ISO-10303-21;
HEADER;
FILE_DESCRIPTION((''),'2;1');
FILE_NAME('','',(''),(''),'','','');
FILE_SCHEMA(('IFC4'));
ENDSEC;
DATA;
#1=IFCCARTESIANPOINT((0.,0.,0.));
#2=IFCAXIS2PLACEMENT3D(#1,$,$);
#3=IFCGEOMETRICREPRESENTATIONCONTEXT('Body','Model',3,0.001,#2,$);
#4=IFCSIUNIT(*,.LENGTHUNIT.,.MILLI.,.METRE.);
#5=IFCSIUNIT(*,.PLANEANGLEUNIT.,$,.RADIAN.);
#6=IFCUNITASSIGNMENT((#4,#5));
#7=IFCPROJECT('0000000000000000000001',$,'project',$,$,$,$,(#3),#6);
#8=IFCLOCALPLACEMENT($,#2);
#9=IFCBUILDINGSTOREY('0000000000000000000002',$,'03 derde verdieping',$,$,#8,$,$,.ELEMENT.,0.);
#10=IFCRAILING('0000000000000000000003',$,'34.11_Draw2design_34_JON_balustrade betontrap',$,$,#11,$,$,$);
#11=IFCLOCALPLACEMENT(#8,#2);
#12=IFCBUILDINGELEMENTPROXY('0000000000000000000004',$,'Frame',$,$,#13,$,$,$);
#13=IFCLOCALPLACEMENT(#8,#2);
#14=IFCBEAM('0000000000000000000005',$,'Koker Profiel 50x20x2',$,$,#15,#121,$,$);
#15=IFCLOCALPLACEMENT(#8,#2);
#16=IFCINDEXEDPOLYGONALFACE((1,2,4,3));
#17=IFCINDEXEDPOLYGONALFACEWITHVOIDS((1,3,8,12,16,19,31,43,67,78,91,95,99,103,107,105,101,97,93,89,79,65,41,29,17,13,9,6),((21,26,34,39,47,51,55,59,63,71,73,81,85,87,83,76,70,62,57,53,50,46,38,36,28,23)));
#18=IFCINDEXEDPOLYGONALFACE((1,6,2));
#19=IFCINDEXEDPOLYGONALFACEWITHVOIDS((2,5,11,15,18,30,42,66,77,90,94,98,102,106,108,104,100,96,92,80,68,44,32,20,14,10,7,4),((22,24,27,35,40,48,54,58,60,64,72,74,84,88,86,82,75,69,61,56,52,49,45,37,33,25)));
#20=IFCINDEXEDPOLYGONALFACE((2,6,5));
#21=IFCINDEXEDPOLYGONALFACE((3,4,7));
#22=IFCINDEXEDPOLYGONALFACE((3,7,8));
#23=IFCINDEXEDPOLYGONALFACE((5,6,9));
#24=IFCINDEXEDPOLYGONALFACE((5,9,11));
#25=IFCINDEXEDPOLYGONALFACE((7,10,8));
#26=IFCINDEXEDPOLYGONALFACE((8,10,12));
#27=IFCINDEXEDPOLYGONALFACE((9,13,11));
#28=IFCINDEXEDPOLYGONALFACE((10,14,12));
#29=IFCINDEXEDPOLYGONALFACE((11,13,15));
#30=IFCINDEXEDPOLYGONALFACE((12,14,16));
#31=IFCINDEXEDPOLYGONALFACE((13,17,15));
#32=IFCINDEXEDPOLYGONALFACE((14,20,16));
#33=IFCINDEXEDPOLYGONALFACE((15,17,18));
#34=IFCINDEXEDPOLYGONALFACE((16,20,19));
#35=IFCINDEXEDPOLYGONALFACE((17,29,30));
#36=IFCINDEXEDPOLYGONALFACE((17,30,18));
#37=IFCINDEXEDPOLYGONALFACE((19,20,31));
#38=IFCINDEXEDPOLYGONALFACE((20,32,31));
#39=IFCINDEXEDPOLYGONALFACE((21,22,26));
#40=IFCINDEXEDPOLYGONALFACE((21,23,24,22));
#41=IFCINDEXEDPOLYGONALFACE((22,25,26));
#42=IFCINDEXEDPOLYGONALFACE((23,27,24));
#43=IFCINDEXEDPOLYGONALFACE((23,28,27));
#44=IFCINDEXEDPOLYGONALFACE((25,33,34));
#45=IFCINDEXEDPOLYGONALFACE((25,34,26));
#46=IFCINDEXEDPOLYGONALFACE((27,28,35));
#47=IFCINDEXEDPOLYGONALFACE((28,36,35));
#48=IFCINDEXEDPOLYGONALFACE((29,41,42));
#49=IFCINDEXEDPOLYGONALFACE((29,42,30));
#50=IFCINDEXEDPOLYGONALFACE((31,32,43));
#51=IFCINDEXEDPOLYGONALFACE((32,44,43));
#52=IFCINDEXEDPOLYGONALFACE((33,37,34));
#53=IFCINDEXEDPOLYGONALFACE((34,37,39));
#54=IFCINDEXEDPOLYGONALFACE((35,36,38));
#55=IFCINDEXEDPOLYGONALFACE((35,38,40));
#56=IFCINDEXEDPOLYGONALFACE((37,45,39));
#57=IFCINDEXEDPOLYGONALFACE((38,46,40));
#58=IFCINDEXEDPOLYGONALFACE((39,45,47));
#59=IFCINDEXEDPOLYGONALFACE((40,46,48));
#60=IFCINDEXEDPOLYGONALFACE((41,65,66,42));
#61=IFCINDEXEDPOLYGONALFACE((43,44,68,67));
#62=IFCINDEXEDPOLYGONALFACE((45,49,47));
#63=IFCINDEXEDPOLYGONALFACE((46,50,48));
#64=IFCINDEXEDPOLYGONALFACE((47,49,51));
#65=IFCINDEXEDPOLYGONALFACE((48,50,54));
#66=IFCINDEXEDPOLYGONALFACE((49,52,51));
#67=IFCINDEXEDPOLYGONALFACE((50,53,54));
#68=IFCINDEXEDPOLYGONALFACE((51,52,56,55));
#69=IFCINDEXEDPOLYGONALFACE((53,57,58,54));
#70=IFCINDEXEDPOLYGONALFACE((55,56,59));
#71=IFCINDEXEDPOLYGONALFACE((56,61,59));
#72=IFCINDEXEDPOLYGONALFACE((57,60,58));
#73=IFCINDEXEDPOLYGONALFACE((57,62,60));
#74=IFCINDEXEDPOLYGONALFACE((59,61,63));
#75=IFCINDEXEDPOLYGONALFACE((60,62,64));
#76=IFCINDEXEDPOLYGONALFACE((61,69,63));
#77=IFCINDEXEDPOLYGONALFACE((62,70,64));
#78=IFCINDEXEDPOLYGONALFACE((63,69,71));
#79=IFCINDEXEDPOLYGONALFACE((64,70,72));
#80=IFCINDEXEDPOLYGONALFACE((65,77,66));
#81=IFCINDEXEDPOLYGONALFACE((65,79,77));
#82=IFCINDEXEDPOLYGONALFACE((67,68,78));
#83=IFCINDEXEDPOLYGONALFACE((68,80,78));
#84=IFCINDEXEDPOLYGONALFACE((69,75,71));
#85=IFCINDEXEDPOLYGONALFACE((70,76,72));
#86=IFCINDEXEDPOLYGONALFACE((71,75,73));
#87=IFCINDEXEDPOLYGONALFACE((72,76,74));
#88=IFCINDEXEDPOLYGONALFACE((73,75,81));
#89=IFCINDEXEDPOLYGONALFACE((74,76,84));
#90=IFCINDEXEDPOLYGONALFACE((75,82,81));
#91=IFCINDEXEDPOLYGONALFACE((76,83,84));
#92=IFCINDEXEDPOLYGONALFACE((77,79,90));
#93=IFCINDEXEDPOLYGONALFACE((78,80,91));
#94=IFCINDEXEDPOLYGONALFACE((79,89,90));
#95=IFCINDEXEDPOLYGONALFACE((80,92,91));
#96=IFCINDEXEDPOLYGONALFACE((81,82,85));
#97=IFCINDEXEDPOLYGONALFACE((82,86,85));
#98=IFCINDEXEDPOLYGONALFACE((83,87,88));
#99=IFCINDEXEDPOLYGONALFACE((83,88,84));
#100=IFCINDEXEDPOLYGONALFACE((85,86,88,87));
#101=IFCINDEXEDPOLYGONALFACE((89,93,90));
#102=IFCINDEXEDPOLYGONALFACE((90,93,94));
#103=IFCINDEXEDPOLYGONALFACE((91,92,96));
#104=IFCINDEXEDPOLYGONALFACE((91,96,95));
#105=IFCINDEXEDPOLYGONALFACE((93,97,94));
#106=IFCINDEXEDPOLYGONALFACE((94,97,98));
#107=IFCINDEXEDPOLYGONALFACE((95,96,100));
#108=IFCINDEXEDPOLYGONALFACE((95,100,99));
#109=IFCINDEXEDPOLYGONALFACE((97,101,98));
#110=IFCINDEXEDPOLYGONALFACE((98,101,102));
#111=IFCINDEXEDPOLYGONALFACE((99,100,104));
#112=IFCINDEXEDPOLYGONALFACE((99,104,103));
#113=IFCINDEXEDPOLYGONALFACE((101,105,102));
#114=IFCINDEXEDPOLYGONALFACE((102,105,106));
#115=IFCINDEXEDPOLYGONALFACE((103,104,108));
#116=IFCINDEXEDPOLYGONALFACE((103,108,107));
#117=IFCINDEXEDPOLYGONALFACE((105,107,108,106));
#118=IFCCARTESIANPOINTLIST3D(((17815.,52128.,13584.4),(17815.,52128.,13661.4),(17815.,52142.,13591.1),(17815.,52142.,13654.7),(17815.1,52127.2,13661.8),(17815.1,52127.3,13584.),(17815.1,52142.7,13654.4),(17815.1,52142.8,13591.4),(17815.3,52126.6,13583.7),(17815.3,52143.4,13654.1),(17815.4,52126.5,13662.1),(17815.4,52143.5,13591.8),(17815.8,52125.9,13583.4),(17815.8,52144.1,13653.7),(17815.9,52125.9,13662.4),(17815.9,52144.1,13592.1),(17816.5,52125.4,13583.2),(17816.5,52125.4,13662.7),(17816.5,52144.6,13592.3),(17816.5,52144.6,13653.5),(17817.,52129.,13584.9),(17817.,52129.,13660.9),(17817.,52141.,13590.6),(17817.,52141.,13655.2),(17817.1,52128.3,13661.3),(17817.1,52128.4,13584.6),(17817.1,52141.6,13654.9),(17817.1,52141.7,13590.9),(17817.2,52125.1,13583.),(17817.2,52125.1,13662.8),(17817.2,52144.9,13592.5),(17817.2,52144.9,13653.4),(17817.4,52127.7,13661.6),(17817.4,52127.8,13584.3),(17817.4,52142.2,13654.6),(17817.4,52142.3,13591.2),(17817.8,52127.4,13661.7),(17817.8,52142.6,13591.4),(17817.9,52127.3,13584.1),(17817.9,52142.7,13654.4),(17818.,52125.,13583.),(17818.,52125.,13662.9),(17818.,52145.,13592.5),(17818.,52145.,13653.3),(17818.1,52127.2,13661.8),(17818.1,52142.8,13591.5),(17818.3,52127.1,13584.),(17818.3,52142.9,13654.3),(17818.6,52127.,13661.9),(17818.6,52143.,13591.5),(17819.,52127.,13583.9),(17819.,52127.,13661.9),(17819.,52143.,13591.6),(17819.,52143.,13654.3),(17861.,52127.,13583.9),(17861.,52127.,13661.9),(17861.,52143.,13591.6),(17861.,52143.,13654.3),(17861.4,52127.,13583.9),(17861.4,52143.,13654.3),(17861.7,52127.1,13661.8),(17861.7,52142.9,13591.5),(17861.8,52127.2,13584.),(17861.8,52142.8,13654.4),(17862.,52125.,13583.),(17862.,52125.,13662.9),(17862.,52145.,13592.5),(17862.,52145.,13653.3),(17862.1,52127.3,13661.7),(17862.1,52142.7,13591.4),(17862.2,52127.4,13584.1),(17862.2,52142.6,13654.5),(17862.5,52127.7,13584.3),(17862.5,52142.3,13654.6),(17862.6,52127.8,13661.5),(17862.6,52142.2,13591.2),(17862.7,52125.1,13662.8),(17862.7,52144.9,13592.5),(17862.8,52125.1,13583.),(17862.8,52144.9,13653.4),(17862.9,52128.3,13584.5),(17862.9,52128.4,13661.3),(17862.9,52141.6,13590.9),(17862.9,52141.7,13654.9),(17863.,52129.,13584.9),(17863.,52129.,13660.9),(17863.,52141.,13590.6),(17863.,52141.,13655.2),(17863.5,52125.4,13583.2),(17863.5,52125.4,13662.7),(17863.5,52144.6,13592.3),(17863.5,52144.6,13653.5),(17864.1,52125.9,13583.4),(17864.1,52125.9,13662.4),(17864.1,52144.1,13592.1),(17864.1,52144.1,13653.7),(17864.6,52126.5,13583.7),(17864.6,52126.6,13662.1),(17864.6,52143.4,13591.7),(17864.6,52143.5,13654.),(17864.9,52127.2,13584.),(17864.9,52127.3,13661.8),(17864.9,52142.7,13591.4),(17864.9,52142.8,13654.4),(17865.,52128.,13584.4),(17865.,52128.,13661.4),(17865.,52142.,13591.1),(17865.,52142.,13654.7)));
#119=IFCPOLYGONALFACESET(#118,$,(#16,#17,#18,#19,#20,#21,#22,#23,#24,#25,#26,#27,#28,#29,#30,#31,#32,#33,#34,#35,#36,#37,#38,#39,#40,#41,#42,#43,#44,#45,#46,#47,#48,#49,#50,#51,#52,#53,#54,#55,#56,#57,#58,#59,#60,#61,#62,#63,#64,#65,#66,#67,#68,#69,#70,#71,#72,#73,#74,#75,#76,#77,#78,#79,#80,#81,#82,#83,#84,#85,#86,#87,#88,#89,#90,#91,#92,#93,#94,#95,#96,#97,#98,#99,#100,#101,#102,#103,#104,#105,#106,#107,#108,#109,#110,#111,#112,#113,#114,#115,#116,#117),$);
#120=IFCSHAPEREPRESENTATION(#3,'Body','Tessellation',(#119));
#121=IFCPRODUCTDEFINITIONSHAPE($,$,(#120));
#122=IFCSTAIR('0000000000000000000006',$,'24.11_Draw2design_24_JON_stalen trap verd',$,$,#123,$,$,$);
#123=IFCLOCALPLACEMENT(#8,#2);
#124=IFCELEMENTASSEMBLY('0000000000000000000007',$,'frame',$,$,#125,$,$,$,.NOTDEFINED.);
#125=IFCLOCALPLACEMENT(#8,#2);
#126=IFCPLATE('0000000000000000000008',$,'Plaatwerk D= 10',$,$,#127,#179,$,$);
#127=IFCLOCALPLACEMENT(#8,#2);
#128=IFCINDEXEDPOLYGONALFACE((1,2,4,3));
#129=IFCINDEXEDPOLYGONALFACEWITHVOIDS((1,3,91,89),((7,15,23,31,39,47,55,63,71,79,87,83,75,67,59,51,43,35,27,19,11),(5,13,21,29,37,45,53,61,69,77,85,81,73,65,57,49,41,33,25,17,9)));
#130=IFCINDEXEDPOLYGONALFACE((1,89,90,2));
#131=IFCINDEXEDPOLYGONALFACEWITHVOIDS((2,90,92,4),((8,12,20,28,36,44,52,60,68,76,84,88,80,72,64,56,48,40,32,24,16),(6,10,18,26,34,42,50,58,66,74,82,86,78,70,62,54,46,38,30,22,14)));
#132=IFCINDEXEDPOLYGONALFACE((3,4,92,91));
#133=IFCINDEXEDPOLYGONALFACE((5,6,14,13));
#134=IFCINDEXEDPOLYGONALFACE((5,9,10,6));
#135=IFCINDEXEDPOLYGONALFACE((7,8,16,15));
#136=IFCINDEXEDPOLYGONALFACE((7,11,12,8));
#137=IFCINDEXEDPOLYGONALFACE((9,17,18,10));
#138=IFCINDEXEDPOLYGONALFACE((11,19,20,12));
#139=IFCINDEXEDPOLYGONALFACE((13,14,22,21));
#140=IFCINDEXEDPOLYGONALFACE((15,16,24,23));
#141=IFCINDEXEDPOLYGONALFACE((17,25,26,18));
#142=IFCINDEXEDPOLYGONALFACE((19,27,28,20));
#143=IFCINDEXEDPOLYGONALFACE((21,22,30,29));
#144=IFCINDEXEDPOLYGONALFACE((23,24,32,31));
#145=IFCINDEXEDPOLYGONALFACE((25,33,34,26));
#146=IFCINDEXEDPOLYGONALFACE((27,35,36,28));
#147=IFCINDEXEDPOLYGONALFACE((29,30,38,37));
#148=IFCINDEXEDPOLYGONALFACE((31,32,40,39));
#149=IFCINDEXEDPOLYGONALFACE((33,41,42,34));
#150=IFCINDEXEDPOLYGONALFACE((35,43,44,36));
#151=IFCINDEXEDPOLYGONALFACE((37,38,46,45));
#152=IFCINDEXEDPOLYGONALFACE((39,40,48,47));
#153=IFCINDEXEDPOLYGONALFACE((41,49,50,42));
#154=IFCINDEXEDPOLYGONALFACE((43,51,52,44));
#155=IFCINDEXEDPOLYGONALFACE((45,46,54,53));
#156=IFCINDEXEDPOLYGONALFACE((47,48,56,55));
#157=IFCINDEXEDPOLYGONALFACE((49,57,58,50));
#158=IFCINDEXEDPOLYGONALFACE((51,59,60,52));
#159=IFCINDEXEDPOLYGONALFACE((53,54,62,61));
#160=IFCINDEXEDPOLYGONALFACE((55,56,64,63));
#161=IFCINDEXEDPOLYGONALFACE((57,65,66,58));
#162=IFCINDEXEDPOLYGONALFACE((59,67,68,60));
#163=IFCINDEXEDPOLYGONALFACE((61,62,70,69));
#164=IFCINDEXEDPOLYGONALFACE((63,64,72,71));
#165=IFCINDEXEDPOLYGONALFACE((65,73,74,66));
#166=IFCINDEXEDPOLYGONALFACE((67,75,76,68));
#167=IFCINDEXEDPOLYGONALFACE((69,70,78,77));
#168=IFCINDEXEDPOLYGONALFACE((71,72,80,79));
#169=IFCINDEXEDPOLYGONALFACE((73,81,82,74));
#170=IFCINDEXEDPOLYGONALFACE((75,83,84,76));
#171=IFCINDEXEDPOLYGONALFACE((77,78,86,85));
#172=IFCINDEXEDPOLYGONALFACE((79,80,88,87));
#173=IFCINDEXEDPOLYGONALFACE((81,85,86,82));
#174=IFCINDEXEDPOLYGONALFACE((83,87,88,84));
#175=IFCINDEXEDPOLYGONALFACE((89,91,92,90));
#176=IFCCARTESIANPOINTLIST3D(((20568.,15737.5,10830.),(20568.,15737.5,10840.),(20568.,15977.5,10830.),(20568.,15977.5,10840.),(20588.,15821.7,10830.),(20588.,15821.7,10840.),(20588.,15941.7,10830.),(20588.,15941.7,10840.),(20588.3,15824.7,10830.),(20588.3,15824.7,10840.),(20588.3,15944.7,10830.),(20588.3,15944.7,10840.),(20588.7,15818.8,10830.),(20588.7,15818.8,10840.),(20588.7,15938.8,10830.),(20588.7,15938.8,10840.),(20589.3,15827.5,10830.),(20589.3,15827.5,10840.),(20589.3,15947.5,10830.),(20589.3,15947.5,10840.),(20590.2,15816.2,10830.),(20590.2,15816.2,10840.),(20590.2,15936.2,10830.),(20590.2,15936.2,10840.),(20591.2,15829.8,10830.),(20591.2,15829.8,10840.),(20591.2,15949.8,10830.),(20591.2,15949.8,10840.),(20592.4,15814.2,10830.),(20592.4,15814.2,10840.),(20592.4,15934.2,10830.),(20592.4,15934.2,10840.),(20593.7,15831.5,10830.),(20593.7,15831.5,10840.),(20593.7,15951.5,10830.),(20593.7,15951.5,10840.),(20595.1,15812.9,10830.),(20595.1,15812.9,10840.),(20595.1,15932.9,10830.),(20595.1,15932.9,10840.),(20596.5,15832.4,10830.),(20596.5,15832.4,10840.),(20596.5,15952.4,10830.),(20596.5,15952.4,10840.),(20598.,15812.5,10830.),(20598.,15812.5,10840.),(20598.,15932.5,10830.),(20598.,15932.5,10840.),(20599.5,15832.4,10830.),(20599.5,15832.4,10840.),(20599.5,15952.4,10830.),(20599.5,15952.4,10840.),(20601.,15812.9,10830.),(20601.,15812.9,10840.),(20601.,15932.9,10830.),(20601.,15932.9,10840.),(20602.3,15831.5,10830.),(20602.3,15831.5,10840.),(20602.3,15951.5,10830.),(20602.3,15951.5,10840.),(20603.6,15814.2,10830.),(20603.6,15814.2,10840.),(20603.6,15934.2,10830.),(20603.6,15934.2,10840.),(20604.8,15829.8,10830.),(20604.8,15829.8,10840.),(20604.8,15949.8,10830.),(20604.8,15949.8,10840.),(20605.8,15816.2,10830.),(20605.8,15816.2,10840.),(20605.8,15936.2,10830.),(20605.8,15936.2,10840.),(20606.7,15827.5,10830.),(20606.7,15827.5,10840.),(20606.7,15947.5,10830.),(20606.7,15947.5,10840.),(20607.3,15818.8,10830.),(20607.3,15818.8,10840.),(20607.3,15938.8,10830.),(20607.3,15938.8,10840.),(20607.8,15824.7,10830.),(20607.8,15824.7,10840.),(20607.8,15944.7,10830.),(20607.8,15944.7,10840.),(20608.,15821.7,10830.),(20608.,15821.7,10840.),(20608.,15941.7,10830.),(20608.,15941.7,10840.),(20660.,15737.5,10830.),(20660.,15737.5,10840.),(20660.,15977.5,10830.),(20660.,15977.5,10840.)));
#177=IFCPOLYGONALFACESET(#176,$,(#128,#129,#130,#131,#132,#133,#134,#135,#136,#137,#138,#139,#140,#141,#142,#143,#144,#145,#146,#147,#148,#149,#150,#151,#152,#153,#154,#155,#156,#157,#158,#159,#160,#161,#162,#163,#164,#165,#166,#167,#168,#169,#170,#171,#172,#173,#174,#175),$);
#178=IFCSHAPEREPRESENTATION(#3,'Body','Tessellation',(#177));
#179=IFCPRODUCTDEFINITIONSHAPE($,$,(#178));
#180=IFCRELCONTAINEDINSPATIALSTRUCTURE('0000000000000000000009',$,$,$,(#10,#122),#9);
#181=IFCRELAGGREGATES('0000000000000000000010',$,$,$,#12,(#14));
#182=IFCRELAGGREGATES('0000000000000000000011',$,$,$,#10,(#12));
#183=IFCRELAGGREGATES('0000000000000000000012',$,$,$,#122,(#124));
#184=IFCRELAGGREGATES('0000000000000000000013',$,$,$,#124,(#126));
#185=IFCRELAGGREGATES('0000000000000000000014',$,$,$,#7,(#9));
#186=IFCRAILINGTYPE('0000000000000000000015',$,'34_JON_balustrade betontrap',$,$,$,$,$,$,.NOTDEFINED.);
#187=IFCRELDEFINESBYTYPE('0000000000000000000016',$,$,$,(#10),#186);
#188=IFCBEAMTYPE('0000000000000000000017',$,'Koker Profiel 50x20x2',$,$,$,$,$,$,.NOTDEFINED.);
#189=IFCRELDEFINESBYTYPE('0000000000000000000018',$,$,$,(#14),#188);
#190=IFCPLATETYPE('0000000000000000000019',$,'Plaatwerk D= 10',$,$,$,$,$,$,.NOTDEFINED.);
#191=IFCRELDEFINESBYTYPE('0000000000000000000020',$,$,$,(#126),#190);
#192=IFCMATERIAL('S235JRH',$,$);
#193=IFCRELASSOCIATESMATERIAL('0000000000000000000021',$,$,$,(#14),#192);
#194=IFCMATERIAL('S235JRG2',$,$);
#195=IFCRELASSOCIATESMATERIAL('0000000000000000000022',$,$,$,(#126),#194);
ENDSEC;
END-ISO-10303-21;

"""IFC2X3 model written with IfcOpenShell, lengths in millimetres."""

from ifc_helpers import new_model, si_unit, frame, origin, origin_2d, place, context, project, spatial, rectangle, hollow_rectangle, circle, extrude, clip, halfspace, source, transform, mapped, material, type_object, element, aggregate, save


model = new_model("IFC2X3")

# Units and contexts
model_context = context("Model", 3, precision=0.001, world=origin(), identifier="Body")
ifc_project = project(units=[si_unit("LENGTHUNIT", "METRE", prefix="MILLI"), si_unit("PLANEANGLEUNIT", "RADIAN")], contexts=[model_context])

# Storey
storey_placement = place(None, origin())
storey = spatial("IfcBuildingStorey", under=ifc_project, at=storey_placement, Name="03 derde verdieping", CompositionType="ELEMENT", Elevation=0.0)

# Shared definitions
railing_type_1 = type_object("IfcRailingType", Name="34_JON_balustrade betontrap")
ifc_material_1 = material(Name="S235JRH")
ifc_material_2 = material(Name="S235JRG2")
beam_type_1 = type_object("IfcBeamType", Name="Koker Profiel 50x20x2")

# Railing, building element proxy
railing_1_placement = place(storey_placement, frame((38619.5, 98107.5, -35301.4), z_axis=(0.0, 0.0, 1.0), x_axis=(-1.0, 0.0, 0.0)))
railing_1 = element("IfcRailing", 1, at=railing_1_placement, inside=storey, type_object=railing_type_1, Name="34.11_Draw2design_34_JON_balustrade betontrap")
proxy_1_placement = place(railing_1_placement, origin())
proxy_1 = element("IfcBuildingElementProxy", 2, at=proxy_1_placement, Name="Frame")

# Beam
shared_shape_1 = source(origin(), model_context, "Body", "Clipping", [
    clip(clip(extrude(hollow_rectangle(XDim=20.0, YDim=50.0, WallThickness=2.0, InnerFilletRadius=2.0, OuterFilletRadius=3.0, at=origin_2d()), origin(), (0.0, 0.0, -1.0), 79.9), halfspace(frame((-10.0, 25.0, -9.6), z_axis=(-0.430948, 0.0, 0.902377), x_axis=(0.902377, 0.0, 0.430948)), False)), halfspace(frame((-10.0, -25.0, -70.3), z_axis=(-0.430948, 0.0, -0.902377), x_axis=(-0.902377, 0.0, 0.430948)), False)),
])
beam_1_placement = place(proxy_1_placement, frame((20779.5, 45972.5, 48964.2), z_axis=(0.0, 0.0, 1.0), x_axis=(0.0, 1.0, 0.0)))
beam_1 = element("IfcBeam", 3, at=beam_1_placement, type_object=beam_type_1, material=ifc_material_1, Name="Koker Profiel 50x20x2", context=model_context, shape_type="MappedRepresentation", body=[
    mapped(shared_shape_1, transform((0.0, 0.0, 0.0), scale=1.0)),
])
aggregate(proxy_1, [beam_1])

aggregate(railing_1, [proxy_1])

# Stair
stair_placement = place(storey_placement, frame((19764.0, 15957.5, 11088.2), z_axis=(0.0, 0.0, 1.0), x_axis=(0.0, -1.0, 0.0)))
stair = element("IfcStair", 4, at=stair_placement, inside=storey, Name="24.11_Draw2design_24_JON_stalen trap verd")

# Element assembly
assembly_placement = place(stair_placement, frame((0.0, 876.0, 0.0), z_axis=(0.0, 0.0, -1.0), x_axis=(1.0, 0.0, 0.0)))
assembly = element("IfcElementAssembly", 5, at=assembly_placement, Name="frame", PredefinedType="NOTDEFINED")
aggregate(stair, [assembly])

# Plate, openings
plate_type = type_object("IfcPlateType", Name="Plaatwerk D= 10")
shared_shape_2 = source(origin(), model_context, "Body", "SweptSolid", [
    extrude(rectangle(XDim=92.0, YDim=240.0, at=origin_2d()), frame((46.0, 0.0, -5.0)), (0.0, 0.0, 1.0), 10.0),
])
plate_1_placement = place(assembly_placement, frame((100.0, 72.0, 253.2), z_axis=(0.0, 0.0, 1.0), x_axis=(0.0, -1.0, 0.0)))
plate_1 = element("IfcPlate", 6, at=plate_1_placement, type_object=plate_type, material=ifc_material_2, Name="Plaatwerk D= 10", context=model_context, shape_type="MappedRepresentation", body=[
    mapped(shared_shape_2, transform((0.0, 0.0, 0.0), scale=1.0)),
])
opening_1_placement = place(plate_1_placement, frame((30.0, -85.0, 5.0), z_axis=(0.0, 0.0, -1.0), x_axis=(0.0, 1.0, 0.0)))
element("IfcOpeningElement", 7, at=opening_1_placement, cuts=plate_1, ObjectType="Opening", context=model_context, shape_type="SweptSolid", body=[
    extrude(circle(Radius=10.0, at=origin_2d()), origin(), (0.0, 0.0, 1.0), 10.0),
])
opening_2_placement = place(plate_1_placement, frame((30.0, 35.0, 5.0), z_axis=(0.0, 0.0, -1.0), x_axis=(0.0, 1.0, 0.0)))
element("IfcOpeningElement", 8, at=opening_2_placement, cuts=plate_1, ObjectType="Opening", context=model_context, shape_type="SweptSolid", body=[
    extrude(circle(Radius=10.0, at=origin_2d()), origin(), (0.0, 0.0, 1.0), 10.0),
])
aggregate(assembly, [plate_1])

save(model, "model.ifc")
